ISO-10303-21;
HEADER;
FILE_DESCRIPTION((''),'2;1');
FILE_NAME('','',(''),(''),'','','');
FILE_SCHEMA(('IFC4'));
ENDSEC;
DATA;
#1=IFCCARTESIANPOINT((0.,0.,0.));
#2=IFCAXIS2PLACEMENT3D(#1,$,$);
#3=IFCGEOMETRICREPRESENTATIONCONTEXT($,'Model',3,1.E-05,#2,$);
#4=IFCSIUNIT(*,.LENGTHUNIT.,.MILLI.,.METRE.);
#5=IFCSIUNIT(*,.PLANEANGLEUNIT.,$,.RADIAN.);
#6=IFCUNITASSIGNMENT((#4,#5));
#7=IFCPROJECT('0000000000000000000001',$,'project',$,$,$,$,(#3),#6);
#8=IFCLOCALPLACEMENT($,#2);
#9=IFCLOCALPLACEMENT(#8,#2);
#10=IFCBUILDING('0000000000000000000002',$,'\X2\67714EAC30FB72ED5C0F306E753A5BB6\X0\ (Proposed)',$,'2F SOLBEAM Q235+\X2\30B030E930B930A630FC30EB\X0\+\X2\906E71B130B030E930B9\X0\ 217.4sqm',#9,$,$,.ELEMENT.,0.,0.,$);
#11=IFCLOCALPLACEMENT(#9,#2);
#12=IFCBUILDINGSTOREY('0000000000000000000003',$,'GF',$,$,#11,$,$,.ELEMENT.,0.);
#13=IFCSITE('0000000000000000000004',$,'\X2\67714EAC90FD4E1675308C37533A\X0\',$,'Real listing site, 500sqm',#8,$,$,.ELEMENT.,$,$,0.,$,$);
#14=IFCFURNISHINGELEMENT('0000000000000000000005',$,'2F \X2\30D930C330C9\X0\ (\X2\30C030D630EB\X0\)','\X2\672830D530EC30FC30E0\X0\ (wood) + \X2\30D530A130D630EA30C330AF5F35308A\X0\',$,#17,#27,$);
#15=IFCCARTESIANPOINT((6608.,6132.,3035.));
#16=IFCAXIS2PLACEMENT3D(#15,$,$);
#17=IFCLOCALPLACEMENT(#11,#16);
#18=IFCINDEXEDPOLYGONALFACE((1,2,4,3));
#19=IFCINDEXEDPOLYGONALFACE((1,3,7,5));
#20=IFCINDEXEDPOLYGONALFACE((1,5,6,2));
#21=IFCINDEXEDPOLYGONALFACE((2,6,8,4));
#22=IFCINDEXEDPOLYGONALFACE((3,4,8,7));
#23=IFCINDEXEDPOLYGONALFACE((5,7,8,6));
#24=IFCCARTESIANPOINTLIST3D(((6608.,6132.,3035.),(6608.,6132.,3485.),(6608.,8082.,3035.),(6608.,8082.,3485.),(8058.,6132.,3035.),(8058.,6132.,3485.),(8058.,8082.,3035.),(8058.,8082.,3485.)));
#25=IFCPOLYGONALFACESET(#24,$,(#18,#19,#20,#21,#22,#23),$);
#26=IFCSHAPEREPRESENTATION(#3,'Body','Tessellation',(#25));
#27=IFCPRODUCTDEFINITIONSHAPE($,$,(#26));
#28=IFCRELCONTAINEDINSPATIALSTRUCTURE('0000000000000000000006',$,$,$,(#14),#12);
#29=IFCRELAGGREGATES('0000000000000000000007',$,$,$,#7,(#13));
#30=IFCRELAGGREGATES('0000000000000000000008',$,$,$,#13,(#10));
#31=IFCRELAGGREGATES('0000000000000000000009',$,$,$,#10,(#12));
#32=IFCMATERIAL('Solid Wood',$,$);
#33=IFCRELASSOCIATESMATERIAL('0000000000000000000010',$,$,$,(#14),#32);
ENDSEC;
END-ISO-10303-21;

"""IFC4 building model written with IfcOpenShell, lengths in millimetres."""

from ifc_helpers import new_model, si_unit, frame, frame_2d, origin, place, context, project, spatial, rectangle, extrude, material, element, save


model = new_model("IFC4")

# Units and contexts
model_context = context("Model", 3, precision=1e-05, world=origin())
ifc_project = project(units=[si_unit("LENGTHUNIT", "METRE", prefix="MILLI"), si_unit("PLANEANGLEUNIT", "RADIAN")], contexts=[model_context])

# Site, building, storey
site_placement = place(None, origin())
site = spatial("IfcSite", under=ifc_project, at=site_placement, Name="東京都世田谷区", ObjectType="Real listing site, 500sqm", CompositionType="ELEMENT", RefElevation=0.0)
building_placement = place(site_placement, origin())
building = spatial("IfcBuilding", under=site, at=building_placement, Name="東京・狭小の町家 (Proposed)", ObjectType="2F SOLBEAM Q235+グラスウール+遮熱グラス 217.4sqm", CompositionType="ELEMENT", ElevationOfRefHeight=0.0, ElevationOfTerrain=0.0)
storey_placement = place(building_placement, origin())
storey = spatial("IfcBuildingStorey", under=building, at=storey_placement, Name="GF", CompositionType="ELEMENT", Elevation=0.0)

# Shared definitions
ifc_material_1 = material(Name="Solid Wood")

# Furnishing element
furnishing_1_placement = place(storey_placement, frame((6608.0, 6132.0, 3035.0)))
element("IfcFurnishingElement", 1, at=furnishing_1_placement, inside=storey, material=ifc_material_1, Name="2F ベッド (ダブル)", Description="木フレーム (wood) + ファブリック張り", context=model_context, shape_type="SweptSolid", body=[
    extrude(rectangle(XDim=1450.0, YDim=1950.0, at=frame_2d((725.0, 975.0))), frame((6608.0, 6132.0, 3035.0)), (0.0, 0.0, 1.0), 450.0),
])

save(model, "model.ifc")
